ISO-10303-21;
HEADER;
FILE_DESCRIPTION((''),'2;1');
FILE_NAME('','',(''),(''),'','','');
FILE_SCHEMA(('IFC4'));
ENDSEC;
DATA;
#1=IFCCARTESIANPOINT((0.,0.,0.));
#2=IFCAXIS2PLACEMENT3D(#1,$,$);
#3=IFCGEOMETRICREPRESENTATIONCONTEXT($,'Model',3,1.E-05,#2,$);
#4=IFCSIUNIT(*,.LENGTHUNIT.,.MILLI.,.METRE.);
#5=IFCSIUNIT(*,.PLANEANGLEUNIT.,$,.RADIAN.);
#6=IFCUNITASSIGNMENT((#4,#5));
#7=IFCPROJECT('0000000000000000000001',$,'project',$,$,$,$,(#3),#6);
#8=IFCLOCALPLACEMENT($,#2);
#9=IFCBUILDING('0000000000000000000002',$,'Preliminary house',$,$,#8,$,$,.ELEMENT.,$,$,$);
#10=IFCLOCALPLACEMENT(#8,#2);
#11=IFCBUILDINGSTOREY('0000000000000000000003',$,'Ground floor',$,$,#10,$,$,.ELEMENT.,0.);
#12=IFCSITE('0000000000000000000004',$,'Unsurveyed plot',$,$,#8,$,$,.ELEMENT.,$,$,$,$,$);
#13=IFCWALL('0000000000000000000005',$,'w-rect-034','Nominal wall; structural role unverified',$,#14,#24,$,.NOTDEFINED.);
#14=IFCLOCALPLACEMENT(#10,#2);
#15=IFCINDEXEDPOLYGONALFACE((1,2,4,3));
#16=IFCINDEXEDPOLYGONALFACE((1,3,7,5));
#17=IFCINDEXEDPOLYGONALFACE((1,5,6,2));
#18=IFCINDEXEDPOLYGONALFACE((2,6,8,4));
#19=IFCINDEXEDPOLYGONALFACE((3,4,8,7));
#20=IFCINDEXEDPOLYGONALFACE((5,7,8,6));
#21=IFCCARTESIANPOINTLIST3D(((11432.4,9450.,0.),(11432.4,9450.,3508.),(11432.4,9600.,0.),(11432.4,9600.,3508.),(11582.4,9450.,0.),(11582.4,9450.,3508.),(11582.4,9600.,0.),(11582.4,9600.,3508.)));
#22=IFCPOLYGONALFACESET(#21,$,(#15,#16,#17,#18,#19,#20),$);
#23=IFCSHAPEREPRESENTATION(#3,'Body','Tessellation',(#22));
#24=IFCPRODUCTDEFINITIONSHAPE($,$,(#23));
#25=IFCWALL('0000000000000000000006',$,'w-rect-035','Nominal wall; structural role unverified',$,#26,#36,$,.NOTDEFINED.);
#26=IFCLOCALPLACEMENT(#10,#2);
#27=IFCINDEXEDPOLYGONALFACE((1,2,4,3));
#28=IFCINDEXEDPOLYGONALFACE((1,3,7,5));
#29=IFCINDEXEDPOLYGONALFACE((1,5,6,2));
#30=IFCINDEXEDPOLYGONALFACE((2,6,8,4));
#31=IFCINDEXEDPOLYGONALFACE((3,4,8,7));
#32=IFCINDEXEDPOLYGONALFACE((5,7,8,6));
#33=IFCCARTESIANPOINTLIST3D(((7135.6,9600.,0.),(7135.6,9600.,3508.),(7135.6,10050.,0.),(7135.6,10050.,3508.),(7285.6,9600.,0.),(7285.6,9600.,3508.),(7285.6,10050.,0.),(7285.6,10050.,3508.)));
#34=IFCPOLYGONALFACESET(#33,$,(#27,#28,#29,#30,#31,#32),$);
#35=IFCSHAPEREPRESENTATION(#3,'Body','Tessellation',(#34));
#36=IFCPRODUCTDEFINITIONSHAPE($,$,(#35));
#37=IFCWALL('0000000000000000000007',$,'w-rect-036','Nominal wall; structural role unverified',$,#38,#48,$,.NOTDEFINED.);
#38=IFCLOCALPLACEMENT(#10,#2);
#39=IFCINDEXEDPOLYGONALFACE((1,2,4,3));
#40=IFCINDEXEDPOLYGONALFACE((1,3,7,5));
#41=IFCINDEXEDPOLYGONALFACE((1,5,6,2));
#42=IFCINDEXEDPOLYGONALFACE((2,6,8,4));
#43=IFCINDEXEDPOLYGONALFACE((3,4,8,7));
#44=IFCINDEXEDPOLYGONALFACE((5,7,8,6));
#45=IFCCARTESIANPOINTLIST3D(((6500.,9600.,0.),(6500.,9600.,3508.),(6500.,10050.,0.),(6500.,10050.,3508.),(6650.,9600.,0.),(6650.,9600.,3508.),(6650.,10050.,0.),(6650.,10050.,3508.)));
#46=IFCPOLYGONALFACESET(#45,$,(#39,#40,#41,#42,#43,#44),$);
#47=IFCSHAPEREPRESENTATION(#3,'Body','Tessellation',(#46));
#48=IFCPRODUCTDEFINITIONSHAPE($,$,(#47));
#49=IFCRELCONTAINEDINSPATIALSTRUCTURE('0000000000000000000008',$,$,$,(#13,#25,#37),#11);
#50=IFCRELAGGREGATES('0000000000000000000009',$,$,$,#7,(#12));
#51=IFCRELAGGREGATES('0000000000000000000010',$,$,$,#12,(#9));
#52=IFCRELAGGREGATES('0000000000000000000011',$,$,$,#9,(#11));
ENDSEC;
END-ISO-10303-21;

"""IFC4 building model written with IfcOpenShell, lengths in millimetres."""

from ifc_helpers import new_model, si_unit, origin, place, context, project, spatial, polyline, outline, extrude, element, save


model = new_model("IFC4")

# Units and contexts
model_context = context("Model", 3, precision=1e-05, world=origin())
ifc_project = project(units=[si_unit("LENGTHUNIT", "METRE", prefix="MILLI"), si_unit("PLANEANGLEUNIT", "RADIAN")], contexts=[model_context])

# Site, building, storey
placement_1 = place(None, origin())
site = spatial("IfcSite", under=ifc_project, at=placement_1, Name="Unsurveyed plot", CompositionType="ELEMENT")
building = spatial("IfcBuilding", under=site, at=placement_1, Name="Preliminary house", CompositionType="ELEMENT")
placement_2 = place(placement_1, origin())
storey = spatial("IfcBuildingStorey", under=building, at=placement_2, Name="Ground floor", CompositionType="ELEMENT", Elevation=0.0)

# Walls
element("IfcWall", 1, at=placement_2, inside=storey, Name="w-rect-034", Description="Nominal wall; structural role unverified", PredefinedType="NOTDEFINED", context=model_context, shape_type="SweptSolid", body=[
    extrude(outline(polyline([(11432.4, 9450.0), (11582.4, 9450.0), (11582.4, 9600.0), (11432.4, 9600.0), (11432.4, 9450.0)])), origin(), (0.0, 0.0, 1.0), 3508.0),
])
element("IfcWall", 2, at=placement_2, inside=storey, Name="w-rect-035", Description="Nominal wall; structural role unverified", PredefinedType="NOTDEFINED", context=model_context, shape_type="SweptSolid", body=[
    extrude(outline(polyline([(7135.6, 9600.0), (7285.6, 9600.0), (7285.6, 10050.0), (7135.6, 10050.0), (7135.6, 9600.0)])), origin(), (0.0, 0.0, 1.0), 3508.0),
])
element("IfcWall", 3, at=placement_2, inside=storey, Name="w-rect-036", Description="Nominal wall; structural role unverified", PredefinedType="NOTDEFINED", context=model_context, shape_type="SweptSolid", body=[
    extrude(outline(polyline([(6500.0, 9600.0), (6650.0, 9600.0), (6650.0, 10050.0), (6500.0, 10050.0), (6500.0, 9600.0)])), origin(), (0.0, 0.0, 1.0), 3508.0),
])

save(model, "model.ifc")
